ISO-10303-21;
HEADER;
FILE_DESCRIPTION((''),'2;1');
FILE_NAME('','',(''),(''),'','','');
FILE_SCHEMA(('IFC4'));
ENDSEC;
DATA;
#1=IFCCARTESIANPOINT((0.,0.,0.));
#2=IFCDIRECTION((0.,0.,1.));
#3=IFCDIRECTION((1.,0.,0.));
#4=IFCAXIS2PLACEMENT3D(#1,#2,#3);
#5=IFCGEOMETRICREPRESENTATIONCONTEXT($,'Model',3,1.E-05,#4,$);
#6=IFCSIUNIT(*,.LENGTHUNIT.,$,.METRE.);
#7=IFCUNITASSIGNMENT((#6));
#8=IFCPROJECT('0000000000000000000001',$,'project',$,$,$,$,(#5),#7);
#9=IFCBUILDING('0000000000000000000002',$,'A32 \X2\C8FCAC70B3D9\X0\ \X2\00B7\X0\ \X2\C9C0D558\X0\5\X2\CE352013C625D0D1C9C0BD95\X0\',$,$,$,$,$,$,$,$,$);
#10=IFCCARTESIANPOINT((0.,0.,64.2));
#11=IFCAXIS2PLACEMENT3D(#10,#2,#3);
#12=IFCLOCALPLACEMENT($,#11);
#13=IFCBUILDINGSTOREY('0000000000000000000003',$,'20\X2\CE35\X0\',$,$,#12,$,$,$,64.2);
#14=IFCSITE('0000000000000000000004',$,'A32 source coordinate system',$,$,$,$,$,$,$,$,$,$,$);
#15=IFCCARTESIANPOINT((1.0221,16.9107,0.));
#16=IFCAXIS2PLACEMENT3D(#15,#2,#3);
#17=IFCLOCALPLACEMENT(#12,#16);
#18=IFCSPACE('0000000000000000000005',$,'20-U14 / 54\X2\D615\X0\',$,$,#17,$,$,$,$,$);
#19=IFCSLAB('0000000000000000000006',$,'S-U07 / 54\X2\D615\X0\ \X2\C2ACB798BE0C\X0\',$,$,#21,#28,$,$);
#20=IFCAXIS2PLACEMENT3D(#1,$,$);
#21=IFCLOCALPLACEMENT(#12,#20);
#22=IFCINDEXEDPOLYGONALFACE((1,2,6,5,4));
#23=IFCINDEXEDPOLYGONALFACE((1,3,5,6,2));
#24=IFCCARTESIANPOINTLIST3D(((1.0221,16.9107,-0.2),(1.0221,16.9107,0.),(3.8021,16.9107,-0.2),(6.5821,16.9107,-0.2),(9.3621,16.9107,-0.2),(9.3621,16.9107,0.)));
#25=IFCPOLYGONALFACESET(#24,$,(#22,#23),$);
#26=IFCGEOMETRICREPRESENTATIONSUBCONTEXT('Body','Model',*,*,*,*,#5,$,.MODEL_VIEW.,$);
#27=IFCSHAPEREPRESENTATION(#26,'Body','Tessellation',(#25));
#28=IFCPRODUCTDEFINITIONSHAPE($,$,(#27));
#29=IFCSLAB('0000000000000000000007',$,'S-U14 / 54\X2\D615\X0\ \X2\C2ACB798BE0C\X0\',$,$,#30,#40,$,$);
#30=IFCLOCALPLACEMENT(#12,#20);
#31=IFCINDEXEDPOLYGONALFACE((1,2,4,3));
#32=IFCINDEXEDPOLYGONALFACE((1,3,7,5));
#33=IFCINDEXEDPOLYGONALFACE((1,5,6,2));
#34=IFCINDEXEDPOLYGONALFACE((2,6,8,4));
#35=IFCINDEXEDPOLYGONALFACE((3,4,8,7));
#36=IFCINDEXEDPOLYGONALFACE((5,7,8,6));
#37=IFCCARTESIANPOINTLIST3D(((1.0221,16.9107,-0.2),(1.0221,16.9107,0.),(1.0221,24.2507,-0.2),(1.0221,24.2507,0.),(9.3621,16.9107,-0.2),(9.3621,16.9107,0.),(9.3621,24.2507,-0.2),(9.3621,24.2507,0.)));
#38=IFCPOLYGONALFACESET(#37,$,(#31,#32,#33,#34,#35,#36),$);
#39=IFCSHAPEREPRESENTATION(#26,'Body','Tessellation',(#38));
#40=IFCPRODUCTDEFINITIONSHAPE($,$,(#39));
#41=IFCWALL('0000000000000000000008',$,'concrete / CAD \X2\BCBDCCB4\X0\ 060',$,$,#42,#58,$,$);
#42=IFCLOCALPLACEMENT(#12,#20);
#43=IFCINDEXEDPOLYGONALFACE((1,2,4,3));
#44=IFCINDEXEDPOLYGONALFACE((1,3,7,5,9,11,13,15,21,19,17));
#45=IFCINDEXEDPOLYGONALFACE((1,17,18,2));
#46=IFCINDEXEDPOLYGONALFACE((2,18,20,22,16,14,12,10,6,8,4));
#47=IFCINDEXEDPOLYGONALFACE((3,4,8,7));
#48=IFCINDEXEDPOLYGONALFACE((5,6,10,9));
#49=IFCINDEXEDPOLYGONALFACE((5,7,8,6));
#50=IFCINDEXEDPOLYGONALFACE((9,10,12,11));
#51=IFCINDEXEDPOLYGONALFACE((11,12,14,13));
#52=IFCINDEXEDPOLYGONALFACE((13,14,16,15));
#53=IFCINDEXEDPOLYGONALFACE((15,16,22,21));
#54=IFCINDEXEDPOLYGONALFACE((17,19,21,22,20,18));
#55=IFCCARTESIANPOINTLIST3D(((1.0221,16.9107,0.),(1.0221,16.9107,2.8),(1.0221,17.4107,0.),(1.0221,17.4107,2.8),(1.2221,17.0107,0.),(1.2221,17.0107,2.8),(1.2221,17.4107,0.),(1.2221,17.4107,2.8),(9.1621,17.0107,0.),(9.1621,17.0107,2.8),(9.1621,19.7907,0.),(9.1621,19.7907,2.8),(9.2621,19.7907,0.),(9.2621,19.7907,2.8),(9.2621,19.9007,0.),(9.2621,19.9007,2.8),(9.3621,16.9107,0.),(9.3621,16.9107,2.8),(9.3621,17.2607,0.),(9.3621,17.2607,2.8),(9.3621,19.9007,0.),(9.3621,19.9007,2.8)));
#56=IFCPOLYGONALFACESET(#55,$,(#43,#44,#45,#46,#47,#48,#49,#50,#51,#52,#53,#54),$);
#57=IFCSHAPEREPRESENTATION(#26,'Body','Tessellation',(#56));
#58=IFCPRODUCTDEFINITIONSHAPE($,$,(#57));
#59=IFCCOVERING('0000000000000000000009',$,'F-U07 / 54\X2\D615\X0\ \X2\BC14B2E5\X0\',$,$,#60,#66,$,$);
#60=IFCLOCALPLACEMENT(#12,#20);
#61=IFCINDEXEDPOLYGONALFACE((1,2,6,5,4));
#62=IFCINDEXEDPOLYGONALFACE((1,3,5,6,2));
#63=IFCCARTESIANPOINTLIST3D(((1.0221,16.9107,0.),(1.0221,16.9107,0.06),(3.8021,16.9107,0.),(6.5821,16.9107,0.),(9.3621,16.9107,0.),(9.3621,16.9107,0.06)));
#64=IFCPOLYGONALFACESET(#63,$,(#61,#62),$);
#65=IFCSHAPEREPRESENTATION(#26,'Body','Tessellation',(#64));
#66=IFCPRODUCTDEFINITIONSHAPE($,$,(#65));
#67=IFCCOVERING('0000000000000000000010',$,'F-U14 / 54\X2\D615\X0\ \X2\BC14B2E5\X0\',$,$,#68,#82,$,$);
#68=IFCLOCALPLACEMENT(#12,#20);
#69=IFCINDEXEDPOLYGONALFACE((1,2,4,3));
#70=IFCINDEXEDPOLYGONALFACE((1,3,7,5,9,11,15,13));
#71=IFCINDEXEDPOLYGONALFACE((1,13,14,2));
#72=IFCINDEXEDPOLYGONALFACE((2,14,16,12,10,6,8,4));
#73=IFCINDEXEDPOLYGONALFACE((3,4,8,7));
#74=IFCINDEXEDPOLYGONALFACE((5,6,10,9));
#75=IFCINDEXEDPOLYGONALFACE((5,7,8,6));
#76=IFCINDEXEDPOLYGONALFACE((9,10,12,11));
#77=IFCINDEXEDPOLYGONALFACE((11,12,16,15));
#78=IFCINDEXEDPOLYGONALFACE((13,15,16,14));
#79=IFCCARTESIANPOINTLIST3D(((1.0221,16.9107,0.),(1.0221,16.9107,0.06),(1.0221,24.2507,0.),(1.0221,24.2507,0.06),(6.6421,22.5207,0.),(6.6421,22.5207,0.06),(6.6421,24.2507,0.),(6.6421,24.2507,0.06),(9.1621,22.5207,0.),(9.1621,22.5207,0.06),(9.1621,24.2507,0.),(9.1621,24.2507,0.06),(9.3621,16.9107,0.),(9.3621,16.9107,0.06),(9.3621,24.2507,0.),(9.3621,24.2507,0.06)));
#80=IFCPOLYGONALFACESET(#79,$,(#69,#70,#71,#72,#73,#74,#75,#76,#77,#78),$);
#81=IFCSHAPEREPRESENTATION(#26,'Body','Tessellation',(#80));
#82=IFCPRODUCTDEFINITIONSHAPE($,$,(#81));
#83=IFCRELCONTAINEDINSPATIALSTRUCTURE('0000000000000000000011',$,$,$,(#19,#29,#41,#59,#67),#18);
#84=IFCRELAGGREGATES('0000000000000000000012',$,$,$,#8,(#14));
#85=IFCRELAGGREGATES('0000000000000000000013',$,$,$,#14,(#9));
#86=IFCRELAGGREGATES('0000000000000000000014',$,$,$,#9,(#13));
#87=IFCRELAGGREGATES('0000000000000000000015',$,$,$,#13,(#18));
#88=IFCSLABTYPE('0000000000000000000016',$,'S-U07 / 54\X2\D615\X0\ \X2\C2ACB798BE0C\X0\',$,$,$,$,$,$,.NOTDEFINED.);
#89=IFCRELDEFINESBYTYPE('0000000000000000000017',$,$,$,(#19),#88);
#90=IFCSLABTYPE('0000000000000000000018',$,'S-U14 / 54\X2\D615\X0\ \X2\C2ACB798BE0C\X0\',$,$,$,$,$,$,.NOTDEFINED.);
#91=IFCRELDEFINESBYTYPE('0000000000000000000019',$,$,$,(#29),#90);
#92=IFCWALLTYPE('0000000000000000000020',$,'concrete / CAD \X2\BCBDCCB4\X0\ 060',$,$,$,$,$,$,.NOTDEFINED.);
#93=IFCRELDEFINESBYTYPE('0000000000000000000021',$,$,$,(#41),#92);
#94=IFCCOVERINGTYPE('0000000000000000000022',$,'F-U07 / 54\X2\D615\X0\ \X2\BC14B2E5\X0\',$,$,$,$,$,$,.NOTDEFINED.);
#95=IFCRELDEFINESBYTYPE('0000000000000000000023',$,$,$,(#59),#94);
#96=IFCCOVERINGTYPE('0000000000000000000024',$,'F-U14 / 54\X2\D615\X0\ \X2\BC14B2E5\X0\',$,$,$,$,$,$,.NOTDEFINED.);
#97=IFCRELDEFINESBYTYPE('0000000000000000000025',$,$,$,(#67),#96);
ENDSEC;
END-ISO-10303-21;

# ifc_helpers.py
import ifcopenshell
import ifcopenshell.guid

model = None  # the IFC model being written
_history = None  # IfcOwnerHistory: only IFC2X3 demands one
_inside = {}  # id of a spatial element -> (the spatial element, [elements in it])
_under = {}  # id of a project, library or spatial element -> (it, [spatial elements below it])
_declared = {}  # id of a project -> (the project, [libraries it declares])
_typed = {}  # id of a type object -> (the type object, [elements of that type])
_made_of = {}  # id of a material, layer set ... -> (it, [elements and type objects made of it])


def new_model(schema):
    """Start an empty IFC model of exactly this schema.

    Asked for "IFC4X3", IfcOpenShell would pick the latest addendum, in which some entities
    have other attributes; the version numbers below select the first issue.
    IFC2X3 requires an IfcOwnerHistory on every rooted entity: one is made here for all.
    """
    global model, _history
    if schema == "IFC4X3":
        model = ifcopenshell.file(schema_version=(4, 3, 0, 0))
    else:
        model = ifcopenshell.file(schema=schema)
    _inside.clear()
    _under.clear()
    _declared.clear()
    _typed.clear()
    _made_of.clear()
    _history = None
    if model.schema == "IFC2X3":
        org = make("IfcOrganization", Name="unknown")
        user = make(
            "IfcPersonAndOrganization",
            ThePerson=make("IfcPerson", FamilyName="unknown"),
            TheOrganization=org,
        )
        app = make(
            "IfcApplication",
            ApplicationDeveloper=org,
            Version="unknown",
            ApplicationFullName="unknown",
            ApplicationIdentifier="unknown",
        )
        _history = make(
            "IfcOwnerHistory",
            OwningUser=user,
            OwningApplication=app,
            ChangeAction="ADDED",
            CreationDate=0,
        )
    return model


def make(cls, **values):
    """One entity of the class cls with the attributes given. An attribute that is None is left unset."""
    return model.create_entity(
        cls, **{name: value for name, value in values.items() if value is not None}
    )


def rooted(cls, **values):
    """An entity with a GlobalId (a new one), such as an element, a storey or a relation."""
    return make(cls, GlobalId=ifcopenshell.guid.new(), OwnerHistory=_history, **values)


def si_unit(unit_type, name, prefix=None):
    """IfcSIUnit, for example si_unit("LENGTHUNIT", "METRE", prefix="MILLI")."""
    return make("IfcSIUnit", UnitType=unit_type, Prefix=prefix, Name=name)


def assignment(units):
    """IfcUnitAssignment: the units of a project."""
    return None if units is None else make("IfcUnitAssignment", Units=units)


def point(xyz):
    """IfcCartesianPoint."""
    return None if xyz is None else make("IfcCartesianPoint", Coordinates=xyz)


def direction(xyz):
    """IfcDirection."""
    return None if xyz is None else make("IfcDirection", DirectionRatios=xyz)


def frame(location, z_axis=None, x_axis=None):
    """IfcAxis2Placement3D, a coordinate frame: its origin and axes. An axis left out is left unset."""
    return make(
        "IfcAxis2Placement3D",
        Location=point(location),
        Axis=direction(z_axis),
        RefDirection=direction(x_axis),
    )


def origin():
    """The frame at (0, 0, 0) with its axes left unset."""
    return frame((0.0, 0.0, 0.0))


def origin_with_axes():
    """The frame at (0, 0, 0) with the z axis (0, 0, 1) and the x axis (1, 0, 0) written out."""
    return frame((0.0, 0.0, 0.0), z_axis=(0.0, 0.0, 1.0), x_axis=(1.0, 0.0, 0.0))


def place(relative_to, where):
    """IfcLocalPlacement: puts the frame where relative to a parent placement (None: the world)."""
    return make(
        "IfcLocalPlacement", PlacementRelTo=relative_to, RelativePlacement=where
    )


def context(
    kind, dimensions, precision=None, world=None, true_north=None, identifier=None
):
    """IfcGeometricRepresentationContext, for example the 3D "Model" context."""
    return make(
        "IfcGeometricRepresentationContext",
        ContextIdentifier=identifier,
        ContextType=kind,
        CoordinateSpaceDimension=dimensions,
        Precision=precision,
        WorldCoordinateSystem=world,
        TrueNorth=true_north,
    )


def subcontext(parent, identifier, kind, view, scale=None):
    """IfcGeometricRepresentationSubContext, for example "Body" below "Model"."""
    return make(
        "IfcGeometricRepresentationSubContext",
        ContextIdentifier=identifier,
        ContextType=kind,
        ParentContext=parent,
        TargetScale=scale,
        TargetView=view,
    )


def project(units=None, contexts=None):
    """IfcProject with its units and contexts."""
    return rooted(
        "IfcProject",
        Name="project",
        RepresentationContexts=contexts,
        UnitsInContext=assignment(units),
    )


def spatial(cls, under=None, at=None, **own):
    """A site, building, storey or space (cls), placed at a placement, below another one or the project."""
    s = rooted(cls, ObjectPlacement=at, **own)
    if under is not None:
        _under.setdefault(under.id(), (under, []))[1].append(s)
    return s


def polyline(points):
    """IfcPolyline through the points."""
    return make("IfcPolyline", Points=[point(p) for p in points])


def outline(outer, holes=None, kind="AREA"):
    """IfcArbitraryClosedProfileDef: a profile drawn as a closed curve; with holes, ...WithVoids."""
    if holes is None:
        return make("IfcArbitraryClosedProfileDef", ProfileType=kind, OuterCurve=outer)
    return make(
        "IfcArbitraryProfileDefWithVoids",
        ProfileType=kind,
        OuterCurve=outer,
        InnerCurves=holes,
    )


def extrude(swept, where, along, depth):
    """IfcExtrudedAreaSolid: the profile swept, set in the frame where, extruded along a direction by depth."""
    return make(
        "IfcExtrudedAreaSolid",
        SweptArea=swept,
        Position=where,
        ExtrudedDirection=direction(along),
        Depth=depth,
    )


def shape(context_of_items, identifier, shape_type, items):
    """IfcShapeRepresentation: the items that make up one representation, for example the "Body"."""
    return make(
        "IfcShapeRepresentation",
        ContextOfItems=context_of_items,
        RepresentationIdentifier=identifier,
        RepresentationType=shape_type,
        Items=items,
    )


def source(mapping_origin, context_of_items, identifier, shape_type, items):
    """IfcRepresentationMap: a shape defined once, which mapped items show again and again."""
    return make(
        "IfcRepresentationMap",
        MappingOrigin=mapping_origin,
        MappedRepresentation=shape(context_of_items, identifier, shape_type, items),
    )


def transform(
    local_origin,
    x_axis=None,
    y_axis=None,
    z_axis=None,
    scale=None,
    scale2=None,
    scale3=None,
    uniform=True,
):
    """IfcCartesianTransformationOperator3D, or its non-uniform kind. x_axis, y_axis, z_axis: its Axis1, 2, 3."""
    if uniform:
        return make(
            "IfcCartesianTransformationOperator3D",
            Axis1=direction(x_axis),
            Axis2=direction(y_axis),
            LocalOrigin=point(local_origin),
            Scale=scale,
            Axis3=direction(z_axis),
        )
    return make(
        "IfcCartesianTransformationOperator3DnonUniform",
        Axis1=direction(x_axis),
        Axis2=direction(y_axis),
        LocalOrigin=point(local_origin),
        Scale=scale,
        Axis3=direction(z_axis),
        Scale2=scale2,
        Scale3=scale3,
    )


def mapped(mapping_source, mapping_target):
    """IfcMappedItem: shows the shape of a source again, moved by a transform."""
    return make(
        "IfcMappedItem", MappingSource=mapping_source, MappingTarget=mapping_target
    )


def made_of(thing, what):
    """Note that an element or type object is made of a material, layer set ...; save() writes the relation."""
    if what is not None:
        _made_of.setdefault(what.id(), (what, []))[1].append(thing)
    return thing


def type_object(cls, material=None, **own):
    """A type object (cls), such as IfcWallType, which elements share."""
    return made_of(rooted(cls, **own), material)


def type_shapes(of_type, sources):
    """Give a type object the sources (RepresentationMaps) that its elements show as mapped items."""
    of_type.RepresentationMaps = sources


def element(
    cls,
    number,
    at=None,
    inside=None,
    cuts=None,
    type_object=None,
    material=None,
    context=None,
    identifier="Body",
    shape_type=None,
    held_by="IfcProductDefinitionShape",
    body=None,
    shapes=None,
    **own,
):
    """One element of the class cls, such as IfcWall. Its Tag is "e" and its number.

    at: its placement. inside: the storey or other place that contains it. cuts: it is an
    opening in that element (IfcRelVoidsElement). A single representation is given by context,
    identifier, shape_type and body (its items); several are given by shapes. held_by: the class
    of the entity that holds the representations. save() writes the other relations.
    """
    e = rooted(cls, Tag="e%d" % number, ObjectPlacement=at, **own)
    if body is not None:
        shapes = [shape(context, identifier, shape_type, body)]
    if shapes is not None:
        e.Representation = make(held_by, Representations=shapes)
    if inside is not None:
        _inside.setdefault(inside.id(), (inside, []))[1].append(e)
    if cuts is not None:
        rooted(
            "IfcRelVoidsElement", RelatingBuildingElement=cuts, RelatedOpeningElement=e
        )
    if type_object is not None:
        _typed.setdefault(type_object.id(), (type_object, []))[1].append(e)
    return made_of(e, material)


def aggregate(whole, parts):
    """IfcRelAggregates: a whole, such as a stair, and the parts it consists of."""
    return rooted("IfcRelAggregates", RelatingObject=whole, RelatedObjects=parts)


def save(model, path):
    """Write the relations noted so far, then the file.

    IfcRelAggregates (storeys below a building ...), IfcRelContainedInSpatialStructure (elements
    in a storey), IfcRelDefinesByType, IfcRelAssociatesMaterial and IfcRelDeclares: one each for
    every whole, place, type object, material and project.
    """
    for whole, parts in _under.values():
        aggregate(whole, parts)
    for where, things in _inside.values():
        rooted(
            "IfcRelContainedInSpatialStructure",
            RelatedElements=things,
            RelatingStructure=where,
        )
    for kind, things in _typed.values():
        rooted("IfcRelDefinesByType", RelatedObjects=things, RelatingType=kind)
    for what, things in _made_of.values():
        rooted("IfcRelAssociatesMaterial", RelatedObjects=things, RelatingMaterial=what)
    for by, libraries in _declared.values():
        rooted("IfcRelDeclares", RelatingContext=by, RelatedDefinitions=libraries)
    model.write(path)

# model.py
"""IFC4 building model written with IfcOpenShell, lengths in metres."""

from ifc_helpers import new_model, si_unit, frame, origin, origin_with_axes, place, context, subcontext, project, spatial, polyline, outline, extrude, source, transform, mapped, type_object, type_shapes, element, save


model = new_model("IFC4")

# Units and contexts
model_context = context("Model", 3, precision=1e-05, world=origin_with_axes())
body_context = subcontext(model_context, "Body", "Model", "MODEL_VIEW")
ifc_project = project(units=[si_unit("LENGTHUNIT", "METRE")], contexts=[model_context])

# Site, building, storey, space
storey_placement = place(None, frame((0.0, 0.0, 64.2), z_axis=(0.0, 0.0, 1.0), x_axis=(1.0, 0.0, 0.0)))
space_1_placement = place(storey_placement, frame((1.0221, 16.9107, 0.0), z_axis=(0.0, 0.0, 1.0), x_axis=(1.0, 0.0, 0.0)))
site = spatial("IfcSite", under=ifc_project, Name="A32 source coordinate system")
building = spatial("IfcBuilding", under=site, Name="A32 주거동 · 지하5층–옥탑지붕")
storey = spatial("IfcBuildingStorey", under=building, at=storey_placement, Name="20층", Elevation=64.2)
space_1 = spatial("IfcSpace", under=storey, at=space_1_placement, Name="20-U14 / 54형")

# Slabs
slab_type_1 = type_object("IfcSlabType", Name="S-U07 / 54형 슬래브", PredefinedType="NOTDEFINED")
shared_shape_1 = source(origin(), body_context, "Body", "SweptSolid", [
    extrude(outline(polyline([(0.0, 0.0), (0.0, 0.0), (8.34, 0.0), (8.34, 0.0), (0.0, 0.0)])), frame((0.0, 0.0, -0.2)), (0.0, 0.0, 1.0), 0.2),
])
type_shapes(slab_type_1, [shared_shape_1])
slab_1_placement = place(space_1_placement, origin_with_axes())
element("IfcSlab", 1, at=slab_1_placement, inside=space_1, type_object=slab_type_1, Name="S-U07 / 54형 슬래브", context=body_context, shape_type="MappedRepresentation", body=[
    mapped(shared_shape_1, transform((0.0, 0.0, 0.0), scale=1.0)),
])
slab_type_2 = type_object("IfcSlabType", Name="S-U14 / 54형 슬래브", PredefinedType="NOTDEFINED")
shared_shape_2 = source(origin(), body_context, "Body", "SweptSolid", [
    extrude(outline(polyline([(0.0, 0.0), (0.0, 7.34), (8.34, 7.34), (8.34, 0.0), (0.0, 0.0)])), frame((0.0, 0.0, -0.2)), (0.0, 0.0, 1.0), 0.2),
])
type_shapes(slab_type_2, [shared_shape_2])
slab_2_placement = place(space_1_placement, origin_with_axes())
element("IfcSlab", 2, at=slab_2_placement, inside=space_1, type_object=slab_type_2, Name="S-U14 / 54형 슬래브", context=body_context, shape_type="MappedRepresentation", body=[
    mapped(shared_shape_2, transform((0.0, 0.0, 0.0), scale=1.0)),
])

# Wall
wall_type_1 = type_object("IfcWallType", Name="concrete / CAD 벽체 060", PredefinedType="NOTDEFINED")
shared_shape_3 = source(origin(), body_context, "Body", "SweptSolid", [
    extrude(outline(polyline([(0.2, 0.5), (0.2, 0.1), (8.14, 0.1), (8.14, 2.88), (8.24, 2.88), (8.24, 2.99), (8.34, 2.99), (8.34, 0.35), (8.34, 0.35), (8.34, 0.0), (0.0, 0.0), (0.0, 0.5), (0.2, 0.5)])), origin(), (0.0, 0.0, 1.0), 2.8),
])
type_shapes(wall_type_1, [shared_shape_3])
wall_1_placement = place(space_1_placement, origin_with_axes())
element("IfcWall", 3, at=wall_1_placement, inside=space_1, type_object=wall_type_1, Name="concrete / CAD 벽체 060", context=body_context, shape_type="MappedRepresentation", body=[
    mapped(shared_shape_3, transform((0.0, 0.0, 0.0), scale=1.0)),
])

# Coverings
covering_type_1 = type_object("IfcCoveringType", Name="F-U07 / 54형 바닥", PredefinedType="NOTDEFINED")
shared_shape_4 = source(origin(), body_context, "Body", "SweptSolid", [
    extrude(outline(polyline([(0.0, 0.0), (0.0, 0.0), (8.34, 0.0), (8.34, 0.0), (0.0, 0.0)])), origin(), (0.0, 0.0, 1.0), 0.06),
])
type_shapes(covering_type_1, [shared_shape_4])
covering_1_placement = place(space_1_placement, origin_with_axes())
element("IfcCovering", 4, at=covering_1_placement, inside=space_1, type_object=covering_type_1, Name="F-U07 / 54형 바닥", context=body_context, shape_type="MappedRepresentation", body=[
    mapped(shared_shape_4, transform((0.0, 0.0, 0.0), scale=1.0)),
])
covering_type_2 = type_object("IfcCoveringType", Name="F-U14 / 54형 바닥", PredefinedType="NOTDEFINED")
shared_shape_5 = source(origin(), body_context, "Body", "SweptSolid", [
    extrude(outline(polyline([(8.14, 7.34), (8.34, 7.34), (8.34, 0.0), (0.0, 0.0), (0.0, 7.34), (5.62, 7.34), (5.62, 5.61), (8.14, 5.61), (8.14, 7.34)])), origin(), (0.0, 0.0, 1.0), 0.06),
])
type_shapes(covering_type_2, [shared_shape_5])
covering_2_placement = place(space_1_placement, origin_with_axes())
element("IfcCovering", 5, at=covering_2_placement, inside=space_1, type_object=covering_type_2, Name="F-U14 / 54형 바닥", context=body_context, shape_type="MappedRepresentation", body=[
    mapped(shared_shape_5, transform((0.0, 0.0, 0.0), scale=1.0)),
])

save(model, "model.ifc")
